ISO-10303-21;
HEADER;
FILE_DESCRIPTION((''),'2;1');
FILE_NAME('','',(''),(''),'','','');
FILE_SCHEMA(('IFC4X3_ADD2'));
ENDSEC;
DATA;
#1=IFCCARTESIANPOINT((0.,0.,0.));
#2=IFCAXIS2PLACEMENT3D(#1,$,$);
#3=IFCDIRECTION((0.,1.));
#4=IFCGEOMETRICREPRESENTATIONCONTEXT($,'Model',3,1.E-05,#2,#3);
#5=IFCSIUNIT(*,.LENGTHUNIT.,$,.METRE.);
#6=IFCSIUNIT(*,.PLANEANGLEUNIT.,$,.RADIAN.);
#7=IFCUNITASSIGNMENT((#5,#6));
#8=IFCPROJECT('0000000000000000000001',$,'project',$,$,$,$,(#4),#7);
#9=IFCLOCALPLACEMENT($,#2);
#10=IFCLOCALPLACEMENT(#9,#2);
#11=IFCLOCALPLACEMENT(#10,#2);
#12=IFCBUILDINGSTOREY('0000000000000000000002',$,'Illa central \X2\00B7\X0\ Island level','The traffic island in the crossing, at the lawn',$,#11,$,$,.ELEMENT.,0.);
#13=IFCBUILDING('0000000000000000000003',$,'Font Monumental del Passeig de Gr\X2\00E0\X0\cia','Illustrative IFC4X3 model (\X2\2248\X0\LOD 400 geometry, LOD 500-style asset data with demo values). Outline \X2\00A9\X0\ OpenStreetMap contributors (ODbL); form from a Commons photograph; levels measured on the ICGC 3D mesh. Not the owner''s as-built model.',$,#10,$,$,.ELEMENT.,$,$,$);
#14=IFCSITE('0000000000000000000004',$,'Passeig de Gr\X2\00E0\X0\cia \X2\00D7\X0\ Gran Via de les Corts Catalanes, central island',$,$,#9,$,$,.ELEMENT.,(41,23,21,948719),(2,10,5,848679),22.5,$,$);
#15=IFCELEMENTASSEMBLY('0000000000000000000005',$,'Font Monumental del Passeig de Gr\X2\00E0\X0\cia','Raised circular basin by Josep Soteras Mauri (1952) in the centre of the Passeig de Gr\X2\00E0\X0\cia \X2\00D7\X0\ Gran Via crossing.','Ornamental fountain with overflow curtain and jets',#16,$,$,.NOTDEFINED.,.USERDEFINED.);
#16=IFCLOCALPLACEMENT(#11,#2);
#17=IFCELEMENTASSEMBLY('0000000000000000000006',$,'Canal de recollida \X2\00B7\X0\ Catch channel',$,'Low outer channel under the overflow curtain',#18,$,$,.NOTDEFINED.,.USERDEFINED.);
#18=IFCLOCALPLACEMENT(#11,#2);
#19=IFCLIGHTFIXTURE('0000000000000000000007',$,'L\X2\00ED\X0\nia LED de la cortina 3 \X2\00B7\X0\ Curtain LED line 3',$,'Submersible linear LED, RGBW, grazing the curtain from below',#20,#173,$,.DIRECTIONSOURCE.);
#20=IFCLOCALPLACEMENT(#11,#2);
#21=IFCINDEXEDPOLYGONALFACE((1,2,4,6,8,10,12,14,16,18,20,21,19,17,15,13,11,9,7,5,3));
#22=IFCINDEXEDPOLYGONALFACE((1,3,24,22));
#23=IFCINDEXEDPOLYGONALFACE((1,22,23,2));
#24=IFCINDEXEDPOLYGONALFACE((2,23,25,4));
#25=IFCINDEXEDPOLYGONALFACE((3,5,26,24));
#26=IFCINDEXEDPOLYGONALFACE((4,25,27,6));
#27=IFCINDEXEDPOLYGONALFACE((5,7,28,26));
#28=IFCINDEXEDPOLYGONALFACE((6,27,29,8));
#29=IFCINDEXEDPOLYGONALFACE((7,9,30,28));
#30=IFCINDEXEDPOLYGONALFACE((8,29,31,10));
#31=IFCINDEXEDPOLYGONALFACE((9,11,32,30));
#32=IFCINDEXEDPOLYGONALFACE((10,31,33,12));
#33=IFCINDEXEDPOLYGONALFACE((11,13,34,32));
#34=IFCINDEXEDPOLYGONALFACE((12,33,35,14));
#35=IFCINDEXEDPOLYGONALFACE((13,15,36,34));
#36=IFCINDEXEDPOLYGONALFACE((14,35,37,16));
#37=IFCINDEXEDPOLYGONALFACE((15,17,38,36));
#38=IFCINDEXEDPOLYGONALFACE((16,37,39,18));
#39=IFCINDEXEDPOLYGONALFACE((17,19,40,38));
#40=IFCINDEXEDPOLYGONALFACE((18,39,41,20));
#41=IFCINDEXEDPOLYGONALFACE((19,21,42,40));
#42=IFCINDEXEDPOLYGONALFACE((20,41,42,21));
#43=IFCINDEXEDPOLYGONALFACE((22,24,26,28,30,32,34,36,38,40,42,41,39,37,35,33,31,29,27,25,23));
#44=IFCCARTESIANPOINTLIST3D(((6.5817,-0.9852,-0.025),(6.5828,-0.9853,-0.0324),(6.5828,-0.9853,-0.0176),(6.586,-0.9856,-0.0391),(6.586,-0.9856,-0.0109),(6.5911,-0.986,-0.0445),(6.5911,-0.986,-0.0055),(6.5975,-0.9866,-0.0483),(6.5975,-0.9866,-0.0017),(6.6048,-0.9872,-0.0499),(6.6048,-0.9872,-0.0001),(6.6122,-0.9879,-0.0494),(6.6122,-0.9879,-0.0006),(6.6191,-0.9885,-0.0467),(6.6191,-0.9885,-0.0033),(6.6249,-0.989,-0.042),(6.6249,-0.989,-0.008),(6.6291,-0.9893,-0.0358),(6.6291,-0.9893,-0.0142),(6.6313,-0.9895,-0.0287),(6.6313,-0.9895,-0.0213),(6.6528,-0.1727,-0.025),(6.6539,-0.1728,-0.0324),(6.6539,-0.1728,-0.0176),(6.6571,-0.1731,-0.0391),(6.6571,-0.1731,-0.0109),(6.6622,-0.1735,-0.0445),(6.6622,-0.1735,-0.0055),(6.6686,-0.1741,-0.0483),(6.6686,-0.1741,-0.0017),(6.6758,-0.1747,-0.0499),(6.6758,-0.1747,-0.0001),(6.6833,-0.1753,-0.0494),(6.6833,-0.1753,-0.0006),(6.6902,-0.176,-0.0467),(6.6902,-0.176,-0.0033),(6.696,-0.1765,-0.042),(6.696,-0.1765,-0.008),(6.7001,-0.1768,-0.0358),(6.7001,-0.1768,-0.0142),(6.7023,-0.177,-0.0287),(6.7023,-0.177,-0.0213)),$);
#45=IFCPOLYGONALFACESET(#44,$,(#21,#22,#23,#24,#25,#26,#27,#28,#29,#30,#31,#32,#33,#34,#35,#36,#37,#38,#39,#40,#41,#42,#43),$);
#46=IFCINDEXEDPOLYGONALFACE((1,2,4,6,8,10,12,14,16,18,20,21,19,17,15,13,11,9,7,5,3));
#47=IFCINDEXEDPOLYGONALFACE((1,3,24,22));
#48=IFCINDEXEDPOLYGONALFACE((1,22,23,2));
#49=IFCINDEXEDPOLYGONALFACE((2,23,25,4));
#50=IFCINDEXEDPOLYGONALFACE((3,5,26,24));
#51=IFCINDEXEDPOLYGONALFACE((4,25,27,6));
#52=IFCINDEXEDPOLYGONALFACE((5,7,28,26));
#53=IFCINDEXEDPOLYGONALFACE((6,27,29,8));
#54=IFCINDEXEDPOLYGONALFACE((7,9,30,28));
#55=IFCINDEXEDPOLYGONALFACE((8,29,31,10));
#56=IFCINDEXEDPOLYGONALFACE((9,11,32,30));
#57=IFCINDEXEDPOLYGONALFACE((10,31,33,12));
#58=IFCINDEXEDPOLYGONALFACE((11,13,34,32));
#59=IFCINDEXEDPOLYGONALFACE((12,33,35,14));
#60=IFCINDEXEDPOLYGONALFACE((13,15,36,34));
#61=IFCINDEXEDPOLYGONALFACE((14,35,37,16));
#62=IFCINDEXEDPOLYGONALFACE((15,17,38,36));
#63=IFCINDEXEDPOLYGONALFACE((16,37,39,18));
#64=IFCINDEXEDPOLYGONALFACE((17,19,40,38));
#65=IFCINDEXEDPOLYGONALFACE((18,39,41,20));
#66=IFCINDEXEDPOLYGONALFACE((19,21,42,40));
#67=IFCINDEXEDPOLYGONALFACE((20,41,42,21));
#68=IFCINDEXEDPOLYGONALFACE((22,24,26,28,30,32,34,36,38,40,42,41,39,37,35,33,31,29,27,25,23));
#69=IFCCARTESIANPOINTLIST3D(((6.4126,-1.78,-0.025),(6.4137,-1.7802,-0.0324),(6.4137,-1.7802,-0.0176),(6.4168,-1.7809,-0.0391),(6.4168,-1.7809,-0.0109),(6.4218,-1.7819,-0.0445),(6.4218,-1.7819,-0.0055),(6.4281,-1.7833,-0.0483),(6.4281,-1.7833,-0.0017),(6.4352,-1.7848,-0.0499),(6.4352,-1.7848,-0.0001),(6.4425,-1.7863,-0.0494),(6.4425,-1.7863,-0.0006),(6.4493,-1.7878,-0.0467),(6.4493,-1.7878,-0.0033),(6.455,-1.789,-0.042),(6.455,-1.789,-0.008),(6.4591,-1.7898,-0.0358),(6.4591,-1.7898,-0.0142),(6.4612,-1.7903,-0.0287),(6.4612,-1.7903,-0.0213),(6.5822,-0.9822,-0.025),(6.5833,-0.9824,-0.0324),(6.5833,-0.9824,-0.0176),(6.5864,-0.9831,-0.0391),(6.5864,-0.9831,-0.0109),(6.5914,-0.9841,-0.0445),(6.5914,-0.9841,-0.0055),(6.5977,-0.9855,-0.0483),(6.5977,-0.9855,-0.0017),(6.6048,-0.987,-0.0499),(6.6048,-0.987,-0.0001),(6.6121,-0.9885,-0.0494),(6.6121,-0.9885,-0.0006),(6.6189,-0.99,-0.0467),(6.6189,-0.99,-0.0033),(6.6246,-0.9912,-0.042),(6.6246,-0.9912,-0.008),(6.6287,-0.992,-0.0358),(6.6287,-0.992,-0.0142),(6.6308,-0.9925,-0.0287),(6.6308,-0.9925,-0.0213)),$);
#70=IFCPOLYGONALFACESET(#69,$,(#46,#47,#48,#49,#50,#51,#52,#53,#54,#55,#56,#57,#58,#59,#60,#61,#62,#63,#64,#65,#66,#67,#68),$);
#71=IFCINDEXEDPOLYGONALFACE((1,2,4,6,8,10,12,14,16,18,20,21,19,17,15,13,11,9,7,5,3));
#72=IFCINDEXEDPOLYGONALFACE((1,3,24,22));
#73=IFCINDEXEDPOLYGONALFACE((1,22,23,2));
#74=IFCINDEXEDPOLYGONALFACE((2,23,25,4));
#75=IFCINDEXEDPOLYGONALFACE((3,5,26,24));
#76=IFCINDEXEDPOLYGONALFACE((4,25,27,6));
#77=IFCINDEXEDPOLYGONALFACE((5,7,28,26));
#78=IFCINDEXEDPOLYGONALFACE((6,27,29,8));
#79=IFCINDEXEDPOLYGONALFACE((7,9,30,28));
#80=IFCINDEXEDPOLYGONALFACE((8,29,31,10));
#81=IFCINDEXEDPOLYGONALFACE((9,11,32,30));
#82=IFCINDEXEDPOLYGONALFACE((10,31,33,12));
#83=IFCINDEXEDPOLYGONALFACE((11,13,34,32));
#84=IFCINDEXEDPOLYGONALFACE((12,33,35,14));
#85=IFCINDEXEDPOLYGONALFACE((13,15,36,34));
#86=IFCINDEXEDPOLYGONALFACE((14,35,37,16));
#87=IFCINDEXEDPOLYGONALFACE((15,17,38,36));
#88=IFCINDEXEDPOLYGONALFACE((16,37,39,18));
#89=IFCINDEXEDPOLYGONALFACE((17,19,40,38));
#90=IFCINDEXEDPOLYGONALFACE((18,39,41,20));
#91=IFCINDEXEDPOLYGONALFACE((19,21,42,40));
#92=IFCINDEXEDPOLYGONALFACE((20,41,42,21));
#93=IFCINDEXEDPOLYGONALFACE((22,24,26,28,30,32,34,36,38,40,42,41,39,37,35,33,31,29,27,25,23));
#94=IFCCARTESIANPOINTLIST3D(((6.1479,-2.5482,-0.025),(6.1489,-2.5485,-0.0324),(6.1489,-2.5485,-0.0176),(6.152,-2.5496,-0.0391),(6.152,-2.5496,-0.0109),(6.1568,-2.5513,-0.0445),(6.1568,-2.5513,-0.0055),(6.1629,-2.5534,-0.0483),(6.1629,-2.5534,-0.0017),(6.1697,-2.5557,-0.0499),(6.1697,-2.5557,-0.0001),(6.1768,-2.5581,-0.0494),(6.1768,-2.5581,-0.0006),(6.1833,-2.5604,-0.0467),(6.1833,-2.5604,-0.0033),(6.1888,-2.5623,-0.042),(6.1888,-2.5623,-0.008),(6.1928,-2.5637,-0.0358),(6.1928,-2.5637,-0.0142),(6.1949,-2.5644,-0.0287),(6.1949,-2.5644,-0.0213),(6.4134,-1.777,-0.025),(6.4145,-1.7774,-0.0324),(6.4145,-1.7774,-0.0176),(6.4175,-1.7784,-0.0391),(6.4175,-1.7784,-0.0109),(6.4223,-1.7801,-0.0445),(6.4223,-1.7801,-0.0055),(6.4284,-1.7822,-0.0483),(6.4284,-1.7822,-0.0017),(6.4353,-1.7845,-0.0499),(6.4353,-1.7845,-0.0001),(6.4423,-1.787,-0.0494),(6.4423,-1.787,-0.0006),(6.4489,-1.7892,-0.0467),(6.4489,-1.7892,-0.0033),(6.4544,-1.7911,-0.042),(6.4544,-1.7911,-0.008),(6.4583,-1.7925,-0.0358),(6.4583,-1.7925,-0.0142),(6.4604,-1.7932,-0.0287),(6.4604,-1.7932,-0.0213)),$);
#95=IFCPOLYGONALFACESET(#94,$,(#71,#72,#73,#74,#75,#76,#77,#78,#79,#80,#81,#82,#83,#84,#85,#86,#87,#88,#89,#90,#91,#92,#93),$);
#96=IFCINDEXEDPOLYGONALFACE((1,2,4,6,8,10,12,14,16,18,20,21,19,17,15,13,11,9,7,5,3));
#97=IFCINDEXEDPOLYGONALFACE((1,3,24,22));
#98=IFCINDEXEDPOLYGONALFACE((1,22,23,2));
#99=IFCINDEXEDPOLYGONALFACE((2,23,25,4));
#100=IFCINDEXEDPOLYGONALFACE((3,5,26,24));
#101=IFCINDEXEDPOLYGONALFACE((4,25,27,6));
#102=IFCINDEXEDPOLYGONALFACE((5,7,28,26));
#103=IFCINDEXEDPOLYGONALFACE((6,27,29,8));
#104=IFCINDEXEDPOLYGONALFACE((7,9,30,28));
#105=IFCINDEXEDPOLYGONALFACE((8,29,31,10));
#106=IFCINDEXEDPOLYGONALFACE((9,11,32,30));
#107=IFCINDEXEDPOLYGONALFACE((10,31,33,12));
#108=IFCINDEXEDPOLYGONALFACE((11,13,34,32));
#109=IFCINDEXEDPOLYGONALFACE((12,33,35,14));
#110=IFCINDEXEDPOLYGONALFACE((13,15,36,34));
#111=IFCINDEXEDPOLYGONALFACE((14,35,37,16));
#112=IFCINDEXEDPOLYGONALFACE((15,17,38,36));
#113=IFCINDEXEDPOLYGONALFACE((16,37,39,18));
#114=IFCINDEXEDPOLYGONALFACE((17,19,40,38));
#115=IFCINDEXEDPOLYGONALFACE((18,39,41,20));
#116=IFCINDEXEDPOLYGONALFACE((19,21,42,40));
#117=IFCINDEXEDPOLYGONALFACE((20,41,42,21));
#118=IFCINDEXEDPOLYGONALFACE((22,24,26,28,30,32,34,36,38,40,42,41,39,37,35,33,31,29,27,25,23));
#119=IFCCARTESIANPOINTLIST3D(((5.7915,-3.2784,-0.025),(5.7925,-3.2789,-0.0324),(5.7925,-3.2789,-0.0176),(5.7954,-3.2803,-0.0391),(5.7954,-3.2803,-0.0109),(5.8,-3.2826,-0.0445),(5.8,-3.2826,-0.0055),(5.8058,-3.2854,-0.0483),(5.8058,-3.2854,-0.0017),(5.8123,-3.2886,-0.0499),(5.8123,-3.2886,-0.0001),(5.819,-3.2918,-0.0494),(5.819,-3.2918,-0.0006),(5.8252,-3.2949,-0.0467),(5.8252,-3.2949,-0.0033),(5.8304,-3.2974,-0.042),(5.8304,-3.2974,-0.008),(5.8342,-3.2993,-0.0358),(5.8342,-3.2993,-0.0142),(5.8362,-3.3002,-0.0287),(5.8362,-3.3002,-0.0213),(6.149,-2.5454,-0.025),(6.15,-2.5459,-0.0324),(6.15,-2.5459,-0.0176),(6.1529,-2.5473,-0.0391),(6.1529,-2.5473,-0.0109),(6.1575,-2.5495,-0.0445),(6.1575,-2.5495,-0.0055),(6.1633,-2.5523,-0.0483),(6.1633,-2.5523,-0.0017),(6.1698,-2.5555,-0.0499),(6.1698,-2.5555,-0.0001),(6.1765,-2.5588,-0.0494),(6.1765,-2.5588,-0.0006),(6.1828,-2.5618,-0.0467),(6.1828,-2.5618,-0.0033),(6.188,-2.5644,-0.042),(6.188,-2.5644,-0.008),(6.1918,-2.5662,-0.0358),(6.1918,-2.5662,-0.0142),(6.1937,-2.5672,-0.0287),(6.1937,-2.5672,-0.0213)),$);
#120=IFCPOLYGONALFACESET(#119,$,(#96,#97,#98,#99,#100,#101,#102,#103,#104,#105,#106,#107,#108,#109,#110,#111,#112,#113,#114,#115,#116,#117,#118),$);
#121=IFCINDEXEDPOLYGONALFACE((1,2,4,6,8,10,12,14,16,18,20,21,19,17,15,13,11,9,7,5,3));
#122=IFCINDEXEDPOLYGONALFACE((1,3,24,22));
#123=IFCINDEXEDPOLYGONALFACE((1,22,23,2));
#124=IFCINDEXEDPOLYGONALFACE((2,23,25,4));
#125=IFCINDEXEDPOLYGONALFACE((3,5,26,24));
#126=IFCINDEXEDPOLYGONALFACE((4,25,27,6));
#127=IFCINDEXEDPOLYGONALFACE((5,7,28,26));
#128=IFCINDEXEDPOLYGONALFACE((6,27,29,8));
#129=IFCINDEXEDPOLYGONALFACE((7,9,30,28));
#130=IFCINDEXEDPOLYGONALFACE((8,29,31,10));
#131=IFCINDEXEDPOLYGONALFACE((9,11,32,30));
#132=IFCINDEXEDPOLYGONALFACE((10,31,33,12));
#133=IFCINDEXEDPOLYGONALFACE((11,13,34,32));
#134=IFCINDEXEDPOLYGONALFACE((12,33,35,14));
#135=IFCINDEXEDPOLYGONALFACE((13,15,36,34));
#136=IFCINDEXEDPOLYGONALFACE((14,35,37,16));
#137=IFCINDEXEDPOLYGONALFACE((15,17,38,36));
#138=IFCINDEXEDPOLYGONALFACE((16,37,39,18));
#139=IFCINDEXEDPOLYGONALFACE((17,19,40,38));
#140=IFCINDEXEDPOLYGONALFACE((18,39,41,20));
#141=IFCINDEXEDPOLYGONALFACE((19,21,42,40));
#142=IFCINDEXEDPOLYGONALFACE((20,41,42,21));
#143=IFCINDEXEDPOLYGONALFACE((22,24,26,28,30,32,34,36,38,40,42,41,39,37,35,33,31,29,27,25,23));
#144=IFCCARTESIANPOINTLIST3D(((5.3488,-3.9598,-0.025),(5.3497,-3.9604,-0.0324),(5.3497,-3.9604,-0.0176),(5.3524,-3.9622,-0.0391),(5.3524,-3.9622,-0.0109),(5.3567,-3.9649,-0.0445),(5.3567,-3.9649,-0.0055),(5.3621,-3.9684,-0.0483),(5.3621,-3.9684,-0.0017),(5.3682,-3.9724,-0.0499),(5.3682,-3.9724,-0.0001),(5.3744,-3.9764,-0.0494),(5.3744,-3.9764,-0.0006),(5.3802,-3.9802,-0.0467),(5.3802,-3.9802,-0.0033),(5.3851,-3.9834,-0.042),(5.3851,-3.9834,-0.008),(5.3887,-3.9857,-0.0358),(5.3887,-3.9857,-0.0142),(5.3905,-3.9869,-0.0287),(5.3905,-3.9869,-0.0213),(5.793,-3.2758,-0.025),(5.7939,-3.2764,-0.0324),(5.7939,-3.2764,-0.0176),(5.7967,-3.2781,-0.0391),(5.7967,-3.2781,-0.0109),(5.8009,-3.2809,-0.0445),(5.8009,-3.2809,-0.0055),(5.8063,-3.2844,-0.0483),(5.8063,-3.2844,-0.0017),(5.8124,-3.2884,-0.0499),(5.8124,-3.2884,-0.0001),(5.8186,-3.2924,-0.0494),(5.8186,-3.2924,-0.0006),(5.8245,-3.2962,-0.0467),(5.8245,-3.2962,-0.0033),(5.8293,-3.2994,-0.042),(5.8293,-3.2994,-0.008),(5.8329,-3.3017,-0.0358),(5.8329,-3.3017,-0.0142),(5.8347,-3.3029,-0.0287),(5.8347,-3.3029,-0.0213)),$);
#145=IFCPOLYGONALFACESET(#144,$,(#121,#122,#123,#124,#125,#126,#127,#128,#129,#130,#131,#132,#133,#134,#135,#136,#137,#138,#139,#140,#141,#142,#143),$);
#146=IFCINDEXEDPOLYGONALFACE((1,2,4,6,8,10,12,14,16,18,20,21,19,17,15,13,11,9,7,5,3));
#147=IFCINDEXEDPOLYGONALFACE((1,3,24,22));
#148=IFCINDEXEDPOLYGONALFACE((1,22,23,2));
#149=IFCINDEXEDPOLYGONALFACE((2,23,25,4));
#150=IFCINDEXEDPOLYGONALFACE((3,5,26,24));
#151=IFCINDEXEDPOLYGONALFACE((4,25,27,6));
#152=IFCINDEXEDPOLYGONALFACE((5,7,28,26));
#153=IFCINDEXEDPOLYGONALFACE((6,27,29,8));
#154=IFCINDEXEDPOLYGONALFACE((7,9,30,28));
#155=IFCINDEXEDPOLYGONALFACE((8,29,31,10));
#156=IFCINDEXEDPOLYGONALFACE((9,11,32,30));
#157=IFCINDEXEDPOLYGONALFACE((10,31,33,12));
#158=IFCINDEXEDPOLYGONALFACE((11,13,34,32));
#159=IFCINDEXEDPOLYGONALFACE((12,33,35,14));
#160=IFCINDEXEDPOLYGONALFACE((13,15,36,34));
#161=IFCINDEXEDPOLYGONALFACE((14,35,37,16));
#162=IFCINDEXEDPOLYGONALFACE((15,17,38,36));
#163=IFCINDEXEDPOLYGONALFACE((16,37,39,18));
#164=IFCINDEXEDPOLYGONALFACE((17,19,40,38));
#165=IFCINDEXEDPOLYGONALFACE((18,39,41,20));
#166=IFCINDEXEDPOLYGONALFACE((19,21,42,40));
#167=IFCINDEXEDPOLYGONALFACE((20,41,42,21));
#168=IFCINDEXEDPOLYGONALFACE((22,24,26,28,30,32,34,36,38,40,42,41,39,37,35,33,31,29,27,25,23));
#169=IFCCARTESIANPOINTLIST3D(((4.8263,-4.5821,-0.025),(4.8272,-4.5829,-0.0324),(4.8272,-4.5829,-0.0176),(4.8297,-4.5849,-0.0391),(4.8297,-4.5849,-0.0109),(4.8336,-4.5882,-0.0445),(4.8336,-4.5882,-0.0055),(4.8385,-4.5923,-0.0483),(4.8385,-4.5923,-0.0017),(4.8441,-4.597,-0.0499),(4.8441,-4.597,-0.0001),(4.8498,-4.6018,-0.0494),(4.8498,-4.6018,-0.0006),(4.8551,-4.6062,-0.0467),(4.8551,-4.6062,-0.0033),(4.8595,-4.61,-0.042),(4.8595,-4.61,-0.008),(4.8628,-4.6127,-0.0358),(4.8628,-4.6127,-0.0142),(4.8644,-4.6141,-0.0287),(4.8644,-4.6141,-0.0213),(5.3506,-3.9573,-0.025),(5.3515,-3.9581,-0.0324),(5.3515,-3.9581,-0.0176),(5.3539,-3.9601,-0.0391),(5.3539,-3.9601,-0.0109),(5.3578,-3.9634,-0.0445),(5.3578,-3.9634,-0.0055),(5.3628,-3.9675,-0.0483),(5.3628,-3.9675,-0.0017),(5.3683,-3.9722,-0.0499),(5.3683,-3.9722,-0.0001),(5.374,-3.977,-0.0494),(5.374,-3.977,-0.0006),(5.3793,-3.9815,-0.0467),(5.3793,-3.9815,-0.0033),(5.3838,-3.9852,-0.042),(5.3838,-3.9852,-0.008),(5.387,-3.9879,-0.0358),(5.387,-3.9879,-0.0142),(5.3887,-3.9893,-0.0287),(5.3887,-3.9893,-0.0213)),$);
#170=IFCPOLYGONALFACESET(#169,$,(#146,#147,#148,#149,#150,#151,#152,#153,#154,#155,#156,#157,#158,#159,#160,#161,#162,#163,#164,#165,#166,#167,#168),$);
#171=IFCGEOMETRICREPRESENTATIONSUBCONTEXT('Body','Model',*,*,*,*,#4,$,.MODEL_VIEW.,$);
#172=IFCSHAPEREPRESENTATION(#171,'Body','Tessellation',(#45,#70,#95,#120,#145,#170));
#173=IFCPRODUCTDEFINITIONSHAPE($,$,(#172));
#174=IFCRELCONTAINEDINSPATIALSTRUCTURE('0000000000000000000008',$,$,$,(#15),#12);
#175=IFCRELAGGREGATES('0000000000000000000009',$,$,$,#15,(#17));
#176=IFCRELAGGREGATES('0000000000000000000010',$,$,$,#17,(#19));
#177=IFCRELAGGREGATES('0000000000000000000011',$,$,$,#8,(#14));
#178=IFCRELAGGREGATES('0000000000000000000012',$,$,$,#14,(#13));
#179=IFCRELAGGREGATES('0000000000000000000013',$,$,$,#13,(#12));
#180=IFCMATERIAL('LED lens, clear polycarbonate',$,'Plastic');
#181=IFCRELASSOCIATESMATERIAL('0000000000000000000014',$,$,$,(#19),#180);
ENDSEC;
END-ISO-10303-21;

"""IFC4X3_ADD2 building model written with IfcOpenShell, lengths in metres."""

from ifc_helpers import new_model, si_unit, direction, frame, origin, origin_2d_with_axis, place, context, subcontext, project, spatial, circle, extrude, material, element, aggregate, save


model = new_model("IFC4X3_ADD2")

# Units and contexts
model_context = context("Model", 3, precision=1e-05, world=origin(), true_north=direction((0.0, 1.0)))
body_context = subcontext(model_context, "Body", "Model", "MODEL_VIEW")
ifc_project = project(units=[si_unit("LENGTHUNIT", "METRE"), si_unit("PLANEANGLEUNIT", "RADIAN")], contexts=[model_context])

# Site, building, storey
site_placement = place(None, origin())
site = spatial("IfcSite", under=ifc_project, at=site_placement, Name="Passeig de Gràcia × Gran Via de les Corts Catalanes, central island", CompositionType="ELEMENT", RefLatitude=(41, 23, 21, 948719), RefLongitude=(2, 10, 5, 848679), RefElevation=22.5)
building_placement = place(site_placement, origin())
building = spatial("IfcBuilding", under=site, at=building_placement, Name="Font Monumental del Passeig de Gràcia", Description="Illustrative IFC4X3 model (≈LOD 400 geometry, LOD 500-style asset data with demo values). Outline © OpenStreetMap contributors (ODbL); form from a Commons photograph; levels measured on the ICGC 3D mesh. Not the owner's as-built model.", CompositionType="ELEMENT")
storey_placement = place(building_placement, origin())
storey = spatial("IfcBuildingStorey", under=building, at=storey_placement, Name="Illa central · Island level", Description="The traffic island in the crossing, at the lawn", CompositionType="ELEMENT", Elevation=0.0)

# Element assemblies, light fixture
assembly_1_placement = place(building_placement, origin())
assembly_1 = element("IfcElementAssembly", 1, at=assembly_1_placement, inside=storey, Name="Font Monumental del Passeig de Gràcia", Description="Raised circular basin by Josep Soteras Mauri (1952) in the centre of the Passeig de Gràcia × Gran Via crossing.", ObjectType="Ornamental fountain with overflow curtain and jets", AssemblyPlace="NOTDEFINED", PredefinedType="USERDEFINED")
assembly_2_placement = place(building_placement, origin())
assembly_2 = element("IfcElementAssembly", 2, at=assembly_2_placement, Name="Canal de recollida · Catch channel", ObjectType="Low outer channel under the overflow curtain", AssemblyPlace="NOTDEFINED", PredefinedType="USERDEFINED")
ifc_material_1 = material(Name="LED lens, clear polycarbonate", Category="Plastic")
light_fixture_1_placement = place(building_placement, origin())
light_fixture_1 = element("IfcLightFixture", 3, at=light_fixture_1_placement, material=ifc_material_1, Name="Línia LED de la cortina 3 · Curtain LED line 3", ObjectType="Submersible linear LED, RGBW, grazing the curtain from below", PredefinedType="DIRECTIONSOURCE", context=body_context, shape_type="SweptSolid", body=[
    extrude(circle(Radius=0.025, at=origin_2d_with_axis()), frame((6.6777, -0.1749, -0.025), z_axis=(-0.087156, -0.996195, 0.0), x_axis=(-0.996195, 0.087156, 0.0)), (0.0, 0.0, 1.0), 0.8156),
    extrude(circle(Radius=0.025, at=origin_2d_with_axis()), frame((6.6066, -0.9874, -0.025), z_axis=(-0.207912, -0.978148, 0.0), x_axis=(-0.978148, 0.207912, 0.0)), (0.0, 0.0, 1.0), 0.8156),
    extrude(circle(Radius=0.025, at=origin_2d_with_axis()), frame((6.4371, -1.7852, -0.025), z_axis=(-0.325568, -0.945519, 0.0), x_axis=(-0.945519, 0.325568, 0.0)), (0.0, 0.0, 1.0), 0.8156),
    extrude(circle(Radius=0.025, at=origin_2d_with_axis()), frame((6.1715, -2.5563, -0.025), z_axis=(-0.438371, -0.898794, 0.0), x_axis=(-0.898794, 0.438371, 0.0)), (0.0, 0.0, 1.0), 0.8156),
    extrude(circle(Radius=0.025, at=origin_2d_with_axis()), frame((5.814, -3.2894, -0.025), z_axis=(-0.544639, -0.838671, 0.0), x_axis=(-0.838671, 0.544639, 0.0)), (0.0, 0.0, 1.0), 0.8156),
    extrude(circle(Radius=0.025, at=origin_2d_with_axis()), frame((5.3698, -3.9734, -0.025), z_axis=(-0.642788, -0.766044, 0.0), x_axis=(-0.766044, 0.642788, 0.0)), (0.0, 0.0, 1.0), 0.8156),
])
aggregate(assembly_1, [assembly_2])
aggregate(assembly_2, [light_fixture_1])

save(model, "model.ifc")
